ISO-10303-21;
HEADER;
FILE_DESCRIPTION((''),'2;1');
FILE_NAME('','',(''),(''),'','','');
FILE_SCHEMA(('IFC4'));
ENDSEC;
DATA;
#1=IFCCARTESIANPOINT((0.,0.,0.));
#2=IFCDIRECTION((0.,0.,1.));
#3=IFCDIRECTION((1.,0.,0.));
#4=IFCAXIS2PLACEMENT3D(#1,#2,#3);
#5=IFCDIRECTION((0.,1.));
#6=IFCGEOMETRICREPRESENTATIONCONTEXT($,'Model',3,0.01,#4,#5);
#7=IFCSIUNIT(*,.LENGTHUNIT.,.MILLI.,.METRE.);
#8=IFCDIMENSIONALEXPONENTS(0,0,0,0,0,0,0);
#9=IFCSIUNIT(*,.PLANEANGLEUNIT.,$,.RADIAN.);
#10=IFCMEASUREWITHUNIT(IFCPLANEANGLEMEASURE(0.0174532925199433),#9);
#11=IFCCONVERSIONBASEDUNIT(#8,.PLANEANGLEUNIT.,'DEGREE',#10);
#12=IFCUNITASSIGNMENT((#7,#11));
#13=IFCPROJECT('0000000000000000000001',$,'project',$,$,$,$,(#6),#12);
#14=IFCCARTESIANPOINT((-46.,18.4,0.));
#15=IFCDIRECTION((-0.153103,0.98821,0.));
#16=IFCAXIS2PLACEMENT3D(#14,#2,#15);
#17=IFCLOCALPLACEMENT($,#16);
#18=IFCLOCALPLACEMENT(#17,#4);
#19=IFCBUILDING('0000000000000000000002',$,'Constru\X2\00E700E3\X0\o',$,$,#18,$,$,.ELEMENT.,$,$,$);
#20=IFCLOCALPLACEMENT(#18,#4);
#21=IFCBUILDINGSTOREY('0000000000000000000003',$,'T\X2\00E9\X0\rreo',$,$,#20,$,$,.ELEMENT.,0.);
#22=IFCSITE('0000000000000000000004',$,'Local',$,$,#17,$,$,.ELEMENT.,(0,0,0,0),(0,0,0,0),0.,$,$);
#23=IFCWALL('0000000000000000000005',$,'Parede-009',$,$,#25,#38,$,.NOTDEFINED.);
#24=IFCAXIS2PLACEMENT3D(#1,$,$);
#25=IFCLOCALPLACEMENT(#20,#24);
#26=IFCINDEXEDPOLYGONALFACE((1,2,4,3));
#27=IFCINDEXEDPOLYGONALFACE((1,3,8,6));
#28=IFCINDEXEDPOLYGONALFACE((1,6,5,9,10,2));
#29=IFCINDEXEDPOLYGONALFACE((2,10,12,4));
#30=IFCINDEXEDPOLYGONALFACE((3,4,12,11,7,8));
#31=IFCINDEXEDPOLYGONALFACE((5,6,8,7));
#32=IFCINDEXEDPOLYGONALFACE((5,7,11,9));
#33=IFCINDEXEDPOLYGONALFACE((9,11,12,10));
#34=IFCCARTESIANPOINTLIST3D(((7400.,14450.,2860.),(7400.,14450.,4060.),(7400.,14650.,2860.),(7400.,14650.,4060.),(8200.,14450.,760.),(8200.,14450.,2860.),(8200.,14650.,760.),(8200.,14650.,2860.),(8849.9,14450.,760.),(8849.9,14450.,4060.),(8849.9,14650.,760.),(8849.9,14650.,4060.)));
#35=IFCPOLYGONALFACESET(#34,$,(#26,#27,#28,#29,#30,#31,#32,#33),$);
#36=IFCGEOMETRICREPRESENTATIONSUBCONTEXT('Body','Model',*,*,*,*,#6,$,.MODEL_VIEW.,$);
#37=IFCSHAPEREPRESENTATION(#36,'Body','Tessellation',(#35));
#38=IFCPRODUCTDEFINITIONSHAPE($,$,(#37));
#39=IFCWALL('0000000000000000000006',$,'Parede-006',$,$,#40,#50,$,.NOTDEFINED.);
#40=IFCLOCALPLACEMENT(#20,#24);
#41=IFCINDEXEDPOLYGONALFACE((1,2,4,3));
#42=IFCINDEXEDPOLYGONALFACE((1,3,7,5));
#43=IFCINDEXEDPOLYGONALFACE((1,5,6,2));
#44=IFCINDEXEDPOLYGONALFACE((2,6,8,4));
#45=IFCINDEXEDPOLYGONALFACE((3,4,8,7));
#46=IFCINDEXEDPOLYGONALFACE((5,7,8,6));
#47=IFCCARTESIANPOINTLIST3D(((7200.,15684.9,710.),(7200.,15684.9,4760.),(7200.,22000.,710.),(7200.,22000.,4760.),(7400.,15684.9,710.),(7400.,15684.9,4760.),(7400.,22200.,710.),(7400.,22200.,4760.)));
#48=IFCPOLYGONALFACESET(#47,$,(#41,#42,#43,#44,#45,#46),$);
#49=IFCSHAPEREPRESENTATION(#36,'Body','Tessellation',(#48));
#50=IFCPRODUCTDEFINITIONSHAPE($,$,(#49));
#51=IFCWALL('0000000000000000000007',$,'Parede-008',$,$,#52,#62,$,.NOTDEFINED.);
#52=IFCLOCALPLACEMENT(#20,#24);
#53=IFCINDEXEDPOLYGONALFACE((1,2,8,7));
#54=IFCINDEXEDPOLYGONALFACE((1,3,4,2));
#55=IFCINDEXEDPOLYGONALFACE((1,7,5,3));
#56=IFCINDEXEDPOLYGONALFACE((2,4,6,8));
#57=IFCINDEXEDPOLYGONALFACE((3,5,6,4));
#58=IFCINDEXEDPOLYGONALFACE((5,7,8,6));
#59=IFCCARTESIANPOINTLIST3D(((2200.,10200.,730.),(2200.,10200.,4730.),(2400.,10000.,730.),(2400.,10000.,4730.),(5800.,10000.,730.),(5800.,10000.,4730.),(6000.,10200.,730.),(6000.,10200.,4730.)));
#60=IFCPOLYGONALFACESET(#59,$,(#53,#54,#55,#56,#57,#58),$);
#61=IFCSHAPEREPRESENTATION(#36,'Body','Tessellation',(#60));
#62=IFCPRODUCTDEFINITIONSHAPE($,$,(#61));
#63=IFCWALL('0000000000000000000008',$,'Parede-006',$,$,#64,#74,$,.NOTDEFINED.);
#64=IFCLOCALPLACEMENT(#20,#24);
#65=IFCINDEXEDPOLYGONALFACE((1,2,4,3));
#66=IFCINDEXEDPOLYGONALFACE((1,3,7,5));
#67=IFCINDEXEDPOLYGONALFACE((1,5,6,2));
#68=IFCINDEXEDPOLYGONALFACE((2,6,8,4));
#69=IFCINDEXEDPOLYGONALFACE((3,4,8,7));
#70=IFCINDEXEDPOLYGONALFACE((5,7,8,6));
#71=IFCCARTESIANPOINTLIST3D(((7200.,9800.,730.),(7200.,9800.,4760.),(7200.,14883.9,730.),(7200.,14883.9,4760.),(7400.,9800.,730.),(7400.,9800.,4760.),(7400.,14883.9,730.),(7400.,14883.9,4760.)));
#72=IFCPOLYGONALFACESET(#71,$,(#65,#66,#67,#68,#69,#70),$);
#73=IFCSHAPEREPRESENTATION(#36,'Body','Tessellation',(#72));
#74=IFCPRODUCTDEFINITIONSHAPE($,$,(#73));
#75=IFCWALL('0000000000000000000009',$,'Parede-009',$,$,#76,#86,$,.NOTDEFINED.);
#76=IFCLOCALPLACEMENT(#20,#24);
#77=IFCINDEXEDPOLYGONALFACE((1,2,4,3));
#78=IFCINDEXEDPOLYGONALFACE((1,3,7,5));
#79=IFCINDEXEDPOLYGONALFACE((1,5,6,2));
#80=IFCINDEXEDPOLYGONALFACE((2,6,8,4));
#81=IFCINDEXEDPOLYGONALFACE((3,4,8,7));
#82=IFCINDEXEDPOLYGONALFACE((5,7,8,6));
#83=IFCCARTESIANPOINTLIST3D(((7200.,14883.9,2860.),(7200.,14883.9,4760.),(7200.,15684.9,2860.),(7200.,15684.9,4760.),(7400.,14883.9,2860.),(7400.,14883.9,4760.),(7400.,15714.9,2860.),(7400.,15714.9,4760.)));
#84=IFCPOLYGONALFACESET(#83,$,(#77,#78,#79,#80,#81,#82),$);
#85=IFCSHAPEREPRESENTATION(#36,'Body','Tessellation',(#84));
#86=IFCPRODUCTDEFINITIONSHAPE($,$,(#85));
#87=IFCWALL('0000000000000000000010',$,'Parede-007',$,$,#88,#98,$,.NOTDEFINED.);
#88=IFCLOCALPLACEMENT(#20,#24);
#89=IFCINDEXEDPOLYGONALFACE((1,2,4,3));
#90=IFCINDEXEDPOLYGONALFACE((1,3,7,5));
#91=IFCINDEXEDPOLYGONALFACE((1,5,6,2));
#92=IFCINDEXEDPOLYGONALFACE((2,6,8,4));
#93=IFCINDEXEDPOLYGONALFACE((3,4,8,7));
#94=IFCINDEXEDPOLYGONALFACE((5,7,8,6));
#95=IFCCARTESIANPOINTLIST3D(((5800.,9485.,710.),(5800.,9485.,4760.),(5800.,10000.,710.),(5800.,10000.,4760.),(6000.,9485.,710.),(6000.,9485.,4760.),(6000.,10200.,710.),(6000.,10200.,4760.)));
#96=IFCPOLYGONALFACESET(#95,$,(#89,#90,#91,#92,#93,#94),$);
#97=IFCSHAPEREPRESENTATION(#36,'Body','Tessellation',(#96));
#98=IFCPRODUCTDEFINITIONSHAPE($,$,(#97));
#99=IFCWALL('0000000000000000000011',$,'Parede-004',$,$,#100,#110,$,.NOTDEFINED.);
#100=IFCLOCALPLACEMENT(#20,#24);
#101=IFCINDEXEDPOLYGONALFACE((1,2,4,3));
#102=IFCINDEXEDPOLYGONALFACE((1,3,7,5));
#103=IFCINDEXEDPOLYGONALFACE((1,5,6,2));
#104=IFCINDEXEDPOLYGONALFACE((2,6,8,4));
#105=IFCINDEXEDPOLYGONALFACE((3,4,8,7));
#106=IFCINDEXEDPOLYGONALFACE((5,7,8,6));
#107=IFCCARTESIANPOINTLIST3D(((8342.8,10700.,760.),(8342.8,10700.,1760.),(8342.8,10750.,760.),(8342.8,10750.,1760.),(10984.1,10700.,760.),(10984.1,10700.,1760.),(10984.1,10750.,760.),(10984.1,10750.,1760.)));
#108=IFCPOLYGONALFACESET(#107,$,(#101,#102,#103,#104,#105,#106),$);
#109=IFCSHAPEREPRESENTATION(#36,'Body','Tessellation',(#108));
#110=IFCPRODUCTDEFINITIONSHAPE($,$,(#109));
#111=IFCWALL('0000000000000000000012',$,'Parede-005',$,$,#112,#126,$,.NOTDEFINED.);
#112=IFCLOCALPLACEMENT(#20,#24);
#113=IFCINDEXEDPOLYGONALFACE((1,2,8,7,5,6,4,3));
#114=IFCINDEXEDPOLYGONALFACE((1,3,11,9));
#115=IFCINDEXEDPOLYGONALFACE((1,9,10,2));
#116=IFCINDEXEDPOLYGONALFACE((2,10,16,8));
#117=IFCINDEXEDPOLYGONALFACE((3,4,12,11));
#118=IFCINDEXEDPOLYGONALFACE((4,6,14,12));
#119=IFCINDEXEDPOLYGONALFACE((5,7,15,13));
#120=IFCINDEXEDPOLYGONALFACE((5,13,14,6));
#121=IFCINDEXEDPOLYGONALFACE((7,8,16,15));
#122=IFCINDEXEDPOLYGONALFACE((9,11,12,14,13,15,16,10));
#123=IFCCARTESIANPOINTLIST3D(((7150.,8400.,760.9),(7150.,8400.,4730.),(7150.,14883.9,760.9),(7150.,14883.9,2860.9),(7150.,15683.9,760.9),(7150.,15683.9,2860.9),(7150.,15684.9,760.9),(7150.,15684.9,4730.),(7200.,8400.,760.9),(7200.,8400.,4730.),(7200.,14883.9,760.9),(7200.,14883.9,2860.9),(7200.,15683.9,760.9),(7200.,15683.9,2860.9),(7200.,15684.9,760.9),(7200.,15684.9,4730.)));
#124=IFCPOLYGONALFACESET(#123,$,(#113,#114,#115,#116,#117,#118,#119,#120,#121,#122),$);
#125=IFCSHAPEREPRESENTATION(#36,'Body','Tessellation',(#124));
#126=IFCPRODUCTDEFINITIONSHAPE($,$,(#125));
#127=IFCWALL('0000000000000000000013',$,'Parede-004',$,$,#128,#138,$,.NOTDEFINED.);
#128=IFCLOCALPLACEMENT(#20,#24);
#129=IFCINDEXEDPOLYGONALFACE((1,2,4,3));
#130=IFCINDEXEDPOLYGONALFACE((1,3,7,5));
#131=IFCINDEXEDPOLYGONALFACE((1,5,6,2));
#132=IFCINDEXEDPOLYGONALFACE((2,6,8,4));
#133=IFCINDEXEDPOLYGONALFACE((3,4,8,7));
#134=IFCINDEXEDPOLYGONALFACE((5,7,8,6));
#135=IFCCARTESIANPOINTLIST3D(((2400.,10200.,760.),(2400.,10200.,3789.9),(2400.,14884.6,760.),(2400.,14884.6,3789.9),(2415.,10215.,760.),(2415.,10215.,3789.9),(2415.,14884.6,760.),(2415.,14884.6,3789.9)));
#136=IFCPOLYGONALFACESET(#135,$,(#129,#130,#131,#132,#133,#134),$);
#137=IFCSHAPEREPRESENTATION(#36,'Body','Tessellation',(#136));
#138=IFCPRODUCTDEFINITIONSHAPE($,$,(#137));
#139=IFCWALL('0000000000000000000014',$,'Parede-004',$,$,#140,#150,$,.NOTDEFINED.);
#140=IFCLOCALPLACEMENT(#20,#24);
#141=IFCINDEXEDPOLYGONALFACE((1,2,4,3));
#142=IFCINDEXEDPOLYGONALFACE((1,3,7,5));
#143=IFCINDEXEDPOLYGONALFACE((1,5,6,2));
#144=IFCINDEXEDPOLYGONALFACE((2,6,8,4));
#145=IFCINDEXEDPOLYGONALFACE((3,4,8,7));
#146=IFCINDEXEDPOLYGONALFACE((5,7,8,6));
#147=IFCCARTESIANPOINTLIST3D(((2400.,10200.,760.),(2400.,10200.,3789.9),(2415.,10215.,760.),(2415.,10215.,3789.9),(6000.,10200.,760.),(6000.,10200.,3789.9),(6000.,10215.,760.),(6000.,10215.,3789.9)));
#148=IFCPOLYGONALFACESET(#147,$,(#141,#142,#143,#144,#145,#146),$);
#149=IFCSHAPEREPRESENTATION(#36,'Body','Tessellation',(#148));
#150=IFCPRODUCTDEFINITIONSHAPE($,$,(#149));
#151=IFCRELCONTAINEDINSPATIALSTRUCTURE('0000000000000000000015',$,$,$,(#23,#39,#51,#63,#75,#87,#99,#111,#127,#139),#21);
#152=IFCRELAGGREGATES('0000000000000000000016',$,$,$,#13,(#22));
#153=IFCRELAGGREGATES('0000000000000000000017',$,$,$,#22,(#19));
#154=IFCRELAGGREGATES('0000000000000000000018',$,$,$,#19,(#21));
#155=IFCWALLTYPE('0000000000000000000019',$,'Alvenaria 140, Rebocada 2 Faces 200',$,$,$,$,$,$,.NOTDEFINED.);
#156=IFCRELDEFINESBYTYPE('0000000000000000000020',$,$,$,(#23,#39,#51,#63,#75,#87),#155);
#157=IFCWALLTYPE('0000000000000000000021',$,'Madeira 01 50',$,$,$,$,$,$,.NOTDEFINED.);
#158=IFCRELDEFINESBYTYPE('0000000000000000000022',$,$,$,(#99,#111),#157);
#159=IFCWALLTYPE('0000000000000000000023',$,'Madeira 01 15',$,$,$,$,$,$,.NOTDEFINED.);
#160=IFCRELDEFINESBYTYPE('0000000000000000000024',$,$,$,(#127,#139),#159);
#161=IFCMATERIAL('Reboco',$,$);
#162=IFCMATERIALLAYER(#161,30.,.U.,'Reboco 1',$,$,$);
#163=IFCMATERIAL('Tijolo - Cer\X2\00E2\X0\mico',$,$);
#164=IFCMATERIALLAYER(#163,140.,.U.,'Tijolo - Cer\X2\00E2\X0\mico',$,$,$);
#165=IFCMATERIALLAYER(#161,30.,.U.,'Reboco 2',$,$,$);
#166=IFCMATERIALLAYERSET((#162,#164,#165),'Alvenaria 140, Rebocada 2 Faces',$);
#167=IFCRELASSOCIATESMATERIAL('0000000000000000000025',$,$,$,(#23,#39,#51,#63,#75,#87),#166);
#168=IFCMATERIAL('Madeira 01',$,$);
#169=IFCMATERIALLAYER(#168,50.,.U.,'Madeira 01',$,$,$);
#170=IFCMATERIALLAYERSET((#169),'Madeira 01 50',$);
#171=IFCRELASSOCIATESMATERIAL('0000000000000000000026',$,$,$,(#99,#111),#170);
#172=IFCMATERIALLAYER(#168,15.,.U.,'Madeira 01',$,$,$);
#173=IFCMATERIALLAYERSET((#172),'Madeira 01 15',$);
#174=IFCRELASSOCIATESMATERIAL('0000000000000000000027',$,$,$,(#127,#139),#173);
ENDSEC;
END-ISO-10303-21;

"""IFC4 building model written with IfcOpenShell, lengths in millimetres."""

from ifc_helpers import new_model, entity, si_unit, converted_unit, direction, frame, origin_with_axes, origin_2d_with_axis, place, context, subcontext, project, spatial, line, indexed_curve, rectangle, outline, extrude, material, layer, layer_set, layer_usage, type_object, element, save


model = new_model("IFC4")

# Units and contexts
model_context = context("Model", 3, precision=0.01, world=origin_with_axes(), true_north=direction((0.0, 1.0)))
body_context = subcontext(model_context, "Body", "Model", "MODEL_VIEW")
ifc_project = project(units=[si_unit("LENGTHUNIT", "METRE", prefix="MILLI"), converted_unit("PLANEANGLEUNIT", "DEGREE", entity("IfcPlaneAngleMeasure", 0.0174532925199433), si_unit("PLANEANGLEUNIT", "RADIAN"), dimensions=[0, 0, 0, 0, 0, 0, 0])], contexts=[model_context])

# Site, building, storey
site_placement = place(None, frame((-46.0, 18.4, 0.0), z_axis=(0.0, 0.0, 1.0), x_axis=(-0.153103, 0.98821, 0.0)))
site = spatial("IfcSite", under=ifc_project, at=site_placement, Name="Local", CompositionType="ELEMENT", RefLatitude=(0, 0, 0, 0), RefLongitude=(0, 0, 0, 0), RefElevation=0.0)
building_placement = place(site_placement, origin_with_axes())
building = spatial("IfcBuilding", under=site, at=building_placement, Name="Construção", CompositionType="ELEMENT")
storey_placement = place(building_placement, origin_with_axes())
storey = spatial("IfcBuildingStorey", under=building, at=storey_placement, Name="Térreo", CompositionType="ELEMENT", Elevation=0.0)

# Wall, opening
ifc_material_1 = material(Name="Reboco")
ifc_layer_1 = layer(ifc_material_1, 30.0, ventilated="UNKNOWN", Name="Reboco 1")
ifc_material_2 = material(Name="Tijolo - Cerâmico")
ifc_layer_2 = layer(ifc_material_2, 140.0, ventilated="UNKNOWN", Name="Tijolo - Cerâmico")
ifc_layer_3 = layer(ifc_material_1, 30.0, ventilated="UNKNOWN", Name="Reboco 2")
ifc_layer_set_1 = layer_set([ifc_layer_1, ifc_layer_2, ifc_layer_3], Name="Alvenaria 140, Rebocada 2 Faces")
ifc_layer_usage_1 = layer_usage(ifc_layer_set_1, "AXIS2", "NEGATIVE", 0.0)
wall_type_1 = type_object("IfcWallType", Name="Alvenaria 140, Rebocada 2 Faces 200", PredefinedType="NOTDEFINED")
wall_1_placement = place(storey_placement, frame((7400.0, 14650.0, 760.0), z_axis=(0.0, 0.0, 1.0), x_axis=(1.0, 0.000002, 0.0)))
wall_1 = element("IfcWall", 1, at=wall_1_placement, inside=storey, type_object=wall_type_1, material=ifc_layer_usage_1, Name="Parede-009", PredefinedType="NOTDEFINED", context=body_context, shape_type="SweptSolid", body=[
    extrude(outline(indexed_curve([(0.0, -200.0), (1450.0, -200.0), (1450.0, 0.0), (0.0, 0.0)], segments=[line(1, 2, 3, 4, 1)])), origin_with_axes(), (0.0, 0.0, 1.0), 3300.0),
])
opening_1_placement = place(wall_1_placement, frame((400.0, 0.0, 0.0), z_axis=(0.0, 0.0, 1.0), x_axis=(1.0, 0.0, 0.0)))
element("IfcOpeningElement", 2, at=opening_1_placement, cuts=wall_1, context=body_context, shape_type="SweptSolid", body=[
    extrude(rectangle(XDim=800.0, YDim=2100.0, at=origin_2d_with_axis()), frame((0.0, -200.0, 1050.0), z_axis=(0.000002, 1.0, 0.0), x_axis=(-1.0, 0.000002, 0.0)), (0.0, 0.0, 1.0), 600.0),
])

# Walls
ifc_layer_usage_2 = layer_usage(ifc_layer_set_1, "AXIS2", "POSITIVE", 0.0)
wall_2_placement = place(storey_placement, frame((7400.0, 15684.9, 710.0), z_axis=(0.0, 0.0, 1.0), x_axis=(0.0, 1.0, 0.0)))
element("IfcWall", 3, at=wall_2_placement, inside=storey, type_object=wall_type_1, material=ifc_layer_usage_2, Name="Parede-006", PredefinedType="NOTDEFINED", context=body_context, shape_type="SweptSolid", body=[
    extrude(outline(indexed_curve([(0.0, 0.0), (6515.1, 0.0), (6315.1, 200.0), (0.0, 200.0)], segments=[line(1, 2, 3, 4, 1)])), origin_with_axes(), (0.0, 0.0, 1.0), 4050.0),
])
ifc_layer_usage_3 = layer_usage(ifc_layer_set_1, "AXIS2", "NEGATIVE", 0.0)
wall_3_placement = place(storey_placement, frame((6000.0, 10000.0, 730.0), z_axis=(0.0, 0.0, 1.0), x_axis=(-1.0, 0.0, 0.0)))
element("IfcWall", 4, at=wall_3_placement, inside=storey, type_object=wall_type_1, material=ifc_layer_usage_3, Name="Parede-008", PredefinedType="NOTDEFINED", context=body_context, shape_type="SweptSolid", body=[
    extrude(outline(indexed_curve([(0.0, -200.0), (3800.0, -200.0), (3600.0, 0.0), (200.0, 0.0)], segments=[line(1, 2, 3, 4, 1)])), origin_with_axes(), (0.0, 0.0, 1.0), 4000.0),
])
ifc_layer_usage_4 = layer_usage(ifc_layer_set_1, "AXIS2", "POSITIVE", 0.0)
wall_4_placement = place(storey_placement, frame((7400.0, 9800.0, 730.0), z_axis=(0.0, 0.0, 1.0), x_axis=(0.0, 1.0, 0.0)))
element("IfcWall", 5, at=wall_4_placement, inside=storey, type_object=wall_type_1, material=ifc_layer_usage_4, Name="Parede-006", PredefinedType="NOTDEFINED", context=body_context, shape_type="SweptSolid", body=[
    extrude(outline(indexed_curve([(0.0, 0.0), (5083.9, 0.0), (5083.9, 200.0), (0.0, 200.0)], segments=[line(1, 2, 3, 4, 1)])), origin_with_axes(), (0.0, 0.0, 1.0), 4030.0),
])
ifc_layer_usage_5 = layer_usage(ifc_layer_set_1, "AXIS2", "NEGATIVE", 0.0)
wall_5_placement = place(storey_placement, frame((7200.0, 14883.9, 2860.0), z_axis=(0.0, 0.0, 1.0), x_axis=(0.0, 1.0, 0.0)))
element("IfcWall", 6, at=wall_5_placement, inside=storey, type_object=wall_type_1, material=ifc_layer_usage_5, Name="Parede-009", PredefinedType="NOTDEFINED", context=body_context, shape_type="SweptSolid", body=[
    extrude(outline(indexed_curve([(0.0, -200.0), (830.9, -200.0), (800.9, 0.0), (0.0, 0.0)], segments=[line(1, 2, 3, 4, 1)])), origin_with_axes(), (0.0, 0.0, 1.0), 1900.0),
])
ifc_layer_usage_6 = layer_usage(ifc_layer_set_1, "AXIS2", "POSITIVE", 0.0)
wall_6_placement = place(storey_placement, frame((6000.0, 9485.0, 710.0), z_axis=(0.0, 0.0, 1.0), x_axis=(0.0, 1.0, 0.0)))
element("IfcWall", 7, at=wall_6_placement, inside=storey, type_object=wall_type_1, material=ifc_layer_usage_6, Name="Parede-007", PredefinedType="NOTDEFINED", context=body_context, shape_type="SweptSolid", body=[
    extrude(outline(indexed_curve([(0.0, 0.0), (715.0, 0.0), (515.0, 200.0), (0.0, 200.0)], segments=[line(1, 2, 3, 4, 1)])), origin_with_axes(), (0.0, 0.0, 1.0), 4050.0),
])
ifc_material_3 = material(Name="Madeira 01")
ifc_layer_4 = layer(ifc_material_3, 50.0, ventilated="UNKNOWN", Name="Madeira 01")
ifc_layer_set_2 = layer_set([ifc_layer_4], Name="Madeira 01 50")
ifc_layer_usage_7 = layer_usage(ifc_layer_set_2, "AXIS2", "POSITIVE", -50.0)
wall_type_2 = type_object("IfcWallType", Name="Madeira 01 50", PredefinedType="NOTDEFINED")
wall_7_placement = place(storey_placement, frame((8342.8, 10750.0, 760.0), z_axis=(0.0, 0.0, 1.0), x_axis=(1.0, 0.0, 0.0)))
element("IfcWall", 8, at=wall_7_placement, inside=storey, type_object=wall_type_2, material=ifc_layer_usage_7, Name="Parede-004", PredefinedType="NOTDEFINED", context=body_context, shape_type="SweptSolid", body=[
    extrude(outline(indexed_curve([(0.0, -50.0), (2641.4, -50.0), (2641.4, 0.0), (0.0, 0.0)], segments=[line(1, 2, 3, 4, 1)])), origin_with_axes(), (0.0, 0.0, 1.0), 1000.0),
])

# Wall, opening
ifc_layer_usage_8 = layer_usage(ifc_layer_set_2, "AXIS2", "NEGATIVE", 50.0)
wall_8_placement = place(storey_placement, frame((7150.0, 15684.9, 760.9), z_axis=(0.0, 0.0, 1.0), x_axis=(0.0, -1.0, 0.0)))
wall_8 = element("IfcWall", 9, at=wall_8_placement, inside=storey, type_object=wall_type_2, material=ifc_layer_usage_8, Name="Parede-005", PredefinedType="NOTDEFINED", context=body_context, shape_type="SweptSolid", body=[
    extrude(outline(indexed_curve([(0.0, 0.0), (7284.9, 0.0), (7284.9, 50.0), (0.0, 50.0)], segments=[line(1, 2, 3, 4, 1)])), origin_with_axes(), (0.0, 0.0, 1.0), 3969.1),
])
opening_2_placement = place(wall_8_placement, frame((400.9, 0.0, 0.0), z_axis=(0.0, 0.0, 1.0), x_axis=(1.0, 0.0, 0.0)))
element("IfcOpeningElement", 10, at=opening_2_placement, cuts=wall_8, context=body_context, shape_type="SweptSolid", body=[
    extrude(rectangle(XDim=800.0, YDim=2100.0, at=origin_2d_with_axis()), frame((0.0, 50.0, 1050.0), z_axis=(0.0, 1.0, 0.0), x_axis=(1.0, 0.0, 0.0)), (0.0, 0.0, -1.0), 150.0),
])

# Walls
ifc_layer_5 = layer(ifc_material_3, 15.0, ventilated="UNKNOWN", Name="Madeira 01")
ifc_layer_set_3 = layer_set([ifc_layer_5], Name="Madeira 01 15")
ifc_layer_usage_9 = layer_usage(ifc_layer_set_3, "AXIS2", "NEGATIVE", 15.0)
wall_type_3 = type_object("IfcWallType", Name="Madeira 01 15", PredefinedType="NOTDEFINED")
wall_9_placement = place(storey_placement, frame((2400.0, 14884.6, 760.0), z_axis=(0.0, 0.0, 1.0), x_axis=(0.0, -1.0, 0.0)))
element("IfcWall", 11, at=wall_9_placement, inside=storey, type_object=wall_type_3, material=ifc_layer_usage_9, Name="Parede-004", PredefinedType="NOTDEFINED", context=body_context, shape_type="SweptSolid", body=[
    extrude(outline(indexed_curve([(0.0, 0.0), (4684.6, 0.0), (4669.6, 15.0), (0.0, 15.0)], segments=[line(1, 2, 3, 4, 1)])), origin_with_axes(), (0.0, 0.0, 1.0), 3029.9),
])
ifc_layer_usage_10 = layer_usage(ifc_layer_set_3, "AXIS2", "NEGATIVE", 15.0)
wall_10_placement = place(storey_placement, frame((2400.0, 10200.0, 760.0), z_axis=(0.0, 0.0, 1.0), x_axis=(1.0, 0.0, 0.0)))
element("IfcWall", 12, at=wall_10_placement, inside=storey, type_object=wall_type_3, material=ifc_layer_usage_10, Name="Parede-004", PredefinedType="NOTDEFINED", context=body_context, shape_type="SweptSolid", body=[
    extrude(outline(indexed_curve([(0.0, 0.0), (3600.0, 0.0), (3600.0, 15.0), (15.0, 15.0)], segments=[line(1, 2, 3, 4, 1)])), origin_with_axes(), (0.0, 0.0, 1.0), 3029.9),
])

save(model, "model.ifc")
